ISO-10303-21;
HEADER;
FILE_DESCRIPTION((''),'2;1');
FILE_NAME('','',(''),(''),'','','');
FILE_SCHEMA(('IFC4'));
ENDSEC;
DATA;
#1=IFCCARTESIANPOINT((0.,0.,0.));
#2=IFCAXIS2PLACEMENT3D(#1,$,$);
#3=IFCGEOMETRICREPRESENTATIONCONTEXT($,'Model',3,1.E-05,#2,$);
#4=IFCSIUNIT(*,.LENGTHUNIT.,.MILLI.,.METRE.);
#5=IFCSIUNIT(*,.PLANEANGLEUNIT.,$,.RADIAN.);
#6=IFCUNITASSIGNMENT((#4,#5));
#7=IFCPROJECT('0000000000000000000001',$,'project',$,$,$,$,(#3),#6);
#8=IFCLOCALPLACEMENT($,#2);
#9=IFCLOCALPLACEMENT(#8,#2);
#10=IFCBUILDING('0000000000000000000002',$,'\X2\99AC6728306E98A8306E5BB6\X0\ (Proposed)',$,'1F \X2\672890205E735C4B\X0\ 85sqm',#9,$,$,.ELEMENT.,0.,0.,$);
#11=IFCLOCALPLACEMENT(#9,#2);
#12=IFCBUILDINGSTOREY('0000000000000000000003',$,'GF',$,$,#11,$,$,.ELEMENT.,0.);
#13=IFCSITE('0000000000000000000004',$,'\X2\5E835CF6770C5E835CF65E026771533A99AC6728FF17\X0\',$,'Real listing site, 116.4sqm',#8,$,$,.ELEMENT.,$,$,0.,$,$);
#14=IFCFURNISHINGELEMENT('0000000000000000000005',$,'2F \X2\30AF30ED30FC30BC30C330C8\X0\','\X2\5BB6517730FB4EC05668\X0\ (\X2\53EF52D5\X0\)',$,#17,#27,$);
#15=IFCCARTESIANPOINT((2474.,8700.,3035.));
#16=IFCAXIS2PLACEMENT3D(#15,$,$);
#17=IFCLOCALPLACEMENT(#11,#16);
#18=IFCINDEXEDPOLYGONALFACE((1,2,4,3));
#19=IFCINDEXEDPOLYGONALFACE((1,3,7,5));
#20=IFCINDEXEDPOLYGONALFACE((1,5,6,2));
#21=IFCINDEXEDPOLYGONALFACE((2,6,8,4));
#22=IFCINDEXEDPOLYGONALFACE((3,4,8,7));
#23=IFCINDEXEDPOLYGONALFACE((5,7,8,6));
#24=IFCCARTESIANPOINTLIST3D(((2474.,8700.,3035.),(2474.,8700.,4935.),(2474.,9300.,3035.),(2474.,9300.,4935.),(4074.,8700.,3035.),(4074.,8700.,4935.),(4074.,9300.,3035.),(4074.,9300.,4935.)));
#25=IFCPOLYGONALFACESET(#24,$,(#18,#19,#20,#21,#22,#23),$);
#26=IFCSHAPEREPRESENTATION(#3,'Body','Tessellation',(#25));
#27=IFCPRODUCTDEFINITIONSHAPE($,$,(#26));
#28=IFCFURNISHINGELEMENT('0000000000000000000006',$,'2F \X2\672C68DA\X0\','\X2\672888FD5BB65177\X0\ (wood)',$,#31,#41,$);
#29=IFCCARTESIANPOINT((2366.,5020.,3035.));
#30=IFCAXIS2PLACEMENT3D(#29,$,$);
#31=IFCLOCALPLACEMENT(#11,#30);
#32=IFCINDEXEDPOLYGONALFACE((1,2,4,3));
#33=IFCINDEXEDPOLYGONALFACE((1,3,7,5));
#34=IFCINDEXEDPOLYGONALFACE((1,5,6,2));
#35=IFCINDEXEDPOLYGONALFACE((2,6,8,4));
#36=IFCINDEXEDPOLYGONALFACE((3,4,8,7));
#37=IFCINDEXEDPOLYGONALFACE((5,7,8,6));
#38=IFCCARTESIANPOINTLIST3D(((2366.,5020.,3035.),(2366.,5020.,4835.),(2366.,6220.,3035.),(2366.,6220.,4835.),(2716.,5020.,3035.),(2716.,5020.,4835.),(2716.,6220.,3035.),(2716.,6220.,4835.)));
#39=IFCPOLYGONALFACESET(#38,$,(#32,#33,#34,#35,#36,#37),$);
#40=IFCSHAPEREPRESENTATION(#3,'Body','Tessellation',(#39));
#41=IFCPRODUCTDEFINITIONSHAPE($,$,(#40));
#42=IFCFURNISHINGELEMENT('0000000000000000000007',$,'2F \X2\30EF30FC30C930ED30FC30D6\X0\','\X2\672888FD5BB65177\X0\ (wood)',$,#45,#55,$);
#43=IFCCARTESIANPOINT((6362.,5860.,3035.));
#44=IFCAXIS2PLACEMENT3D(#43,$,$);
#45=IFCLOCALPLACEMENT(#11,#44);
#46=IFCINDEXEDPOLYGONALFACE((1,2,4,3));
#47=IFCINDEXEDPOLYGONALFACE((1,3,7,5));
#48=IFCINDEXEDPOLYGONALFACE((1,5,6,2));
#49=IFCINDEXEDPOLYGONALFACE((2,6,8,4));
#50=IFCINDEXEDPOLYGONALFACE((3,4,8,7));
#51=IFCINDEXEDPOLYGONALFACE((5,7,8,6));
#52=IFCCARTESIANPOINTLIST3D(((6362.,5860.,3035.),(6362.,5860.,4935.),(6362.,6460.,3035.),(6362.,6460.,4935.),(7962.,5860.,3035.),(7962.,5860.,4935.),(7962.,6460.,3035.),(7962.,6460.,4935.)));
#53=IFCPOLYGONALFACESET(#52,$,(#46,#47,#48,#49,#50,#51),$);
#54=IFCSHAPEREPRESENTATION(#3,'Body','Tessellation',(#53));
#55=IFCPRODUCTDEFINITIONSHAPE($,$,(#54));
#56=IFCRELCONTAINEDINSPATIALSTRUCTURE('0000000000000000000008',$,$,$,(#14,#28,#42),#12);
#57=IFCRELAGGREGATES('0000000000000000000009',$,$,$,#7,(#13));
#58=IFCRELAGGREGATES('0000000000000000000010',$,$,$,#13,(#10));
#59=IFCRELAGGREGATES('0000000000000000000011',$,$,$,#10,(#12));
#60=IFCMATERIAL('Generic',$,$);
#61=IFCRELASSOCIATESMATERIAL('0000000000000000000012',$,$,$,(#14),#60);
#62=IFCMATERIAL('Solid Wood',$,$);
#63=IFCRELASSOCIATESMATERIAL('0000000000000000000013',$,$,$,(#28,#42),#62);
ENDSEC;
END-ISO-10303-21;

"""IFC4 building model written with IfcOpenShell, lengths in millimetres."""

from ifc_helpers import new_model, si_unit, frame, frame_2d, origin, place, context, project, spatial, rectangle, extrude, material, element, save


model = new_model("IFC4")

# Units and contexts
model_context = context("Model", 3, precision=1e-05, world=origin())
ifc_project = project(units=[si_unit("LENGTHUNIT", "METRE", prefix="MILLI"), si_unit("PLANEANGLEUNIT", "RADIAN")], contexts=[model_context])

# Site, building, storey
site_placement = place(None, origin())
site = spatial("IfcSite", under=ifc_project, at=site_placement, Name="広島県広島市東区馬木７", ObjectType="Real listing site, 116.4sqm", CompositionType="ELEMENT", RefElevation=0.0)
building_placement = place(site_placement, origin())
building = spatial("IfcBuilding", under=site, at=building_placement, Name="馬木の風の家 (Proposed)", ObjectType="1F 木造平屋 85sqm", CompositionType="ELEMENT", ElevationOfRefHeight=0.0, ElevationOfTerrain=0.0)
storey_placement = place(building_placement, origin())
storey = spatial("IfcBuildingStorey", under=building, at=storey_placement, Name="GF", CompositionType="ELEMENT", Elevation=0.0)

# Shared definitions
ifc_material_1 = material(Name="Solid Wood")

# Shared definitions
ifc_material_2 = material(Name="Generic")

# Furnishing elements
furnishing_1_placement = place(storey_placement, frame((2474.0, 8700.0, 3035.0)))
element("IfcFurnishingElement", 1, at=furnishing_1_placement, inside=storey, material=ifc_material_2, Name="2F クローゼット", Description="家具・什器 (可動)", context=model_context, shape_type="SweptSolid", body=[
    extrude(rectangle(XDim=1600.0, YDim=600.0, at=frame_2d((800.0, 300.0))), frame((2474.0, 8700.0, 3035.0)), (0.0, 0.0, 1.0), 1900.0),
])
furnishing_2_placement = place(storey_placement, frame((2366.0, 5020.0, 3035.0)))
element("IfcFurnishingElement", 2, at=furnishing_2_placement, inside=storey, material=ifc_material_1, Name="2F 本棚", Description="木製家具 (wood)", context=model_context, shape_type="SweptSolid", body=[
    extrude(rectangle(XDim=350.0, YDim=1200.0, at=frame_2d((175.0, 600.0))), frame((2366.0, 5020.0, 3035.0)), (0.0, 0.0, 1.0), 1800.0),
])
furnishing_3_placement = place(storey_placement, frame((6362.0, 5860.0, 3035.0)))
element("IfcFurnishingElement", 3, at=furnishing_3_placement, inside=storey, material=ifc_material_1, Name="2F ワードローブ", Description="木製家具 (wood)", context=model_context, shape_type="SweptSolid", body=[
    extrude(rectangle(XDim=1600.0, YDim=600.0, at=frame_2d((800.0, 300.0))), frame((6362.0, 5860.0, 3035.0)), (0.0, 0.0, 1.0), 1900.0),
])

save(model, "model.ifc")
